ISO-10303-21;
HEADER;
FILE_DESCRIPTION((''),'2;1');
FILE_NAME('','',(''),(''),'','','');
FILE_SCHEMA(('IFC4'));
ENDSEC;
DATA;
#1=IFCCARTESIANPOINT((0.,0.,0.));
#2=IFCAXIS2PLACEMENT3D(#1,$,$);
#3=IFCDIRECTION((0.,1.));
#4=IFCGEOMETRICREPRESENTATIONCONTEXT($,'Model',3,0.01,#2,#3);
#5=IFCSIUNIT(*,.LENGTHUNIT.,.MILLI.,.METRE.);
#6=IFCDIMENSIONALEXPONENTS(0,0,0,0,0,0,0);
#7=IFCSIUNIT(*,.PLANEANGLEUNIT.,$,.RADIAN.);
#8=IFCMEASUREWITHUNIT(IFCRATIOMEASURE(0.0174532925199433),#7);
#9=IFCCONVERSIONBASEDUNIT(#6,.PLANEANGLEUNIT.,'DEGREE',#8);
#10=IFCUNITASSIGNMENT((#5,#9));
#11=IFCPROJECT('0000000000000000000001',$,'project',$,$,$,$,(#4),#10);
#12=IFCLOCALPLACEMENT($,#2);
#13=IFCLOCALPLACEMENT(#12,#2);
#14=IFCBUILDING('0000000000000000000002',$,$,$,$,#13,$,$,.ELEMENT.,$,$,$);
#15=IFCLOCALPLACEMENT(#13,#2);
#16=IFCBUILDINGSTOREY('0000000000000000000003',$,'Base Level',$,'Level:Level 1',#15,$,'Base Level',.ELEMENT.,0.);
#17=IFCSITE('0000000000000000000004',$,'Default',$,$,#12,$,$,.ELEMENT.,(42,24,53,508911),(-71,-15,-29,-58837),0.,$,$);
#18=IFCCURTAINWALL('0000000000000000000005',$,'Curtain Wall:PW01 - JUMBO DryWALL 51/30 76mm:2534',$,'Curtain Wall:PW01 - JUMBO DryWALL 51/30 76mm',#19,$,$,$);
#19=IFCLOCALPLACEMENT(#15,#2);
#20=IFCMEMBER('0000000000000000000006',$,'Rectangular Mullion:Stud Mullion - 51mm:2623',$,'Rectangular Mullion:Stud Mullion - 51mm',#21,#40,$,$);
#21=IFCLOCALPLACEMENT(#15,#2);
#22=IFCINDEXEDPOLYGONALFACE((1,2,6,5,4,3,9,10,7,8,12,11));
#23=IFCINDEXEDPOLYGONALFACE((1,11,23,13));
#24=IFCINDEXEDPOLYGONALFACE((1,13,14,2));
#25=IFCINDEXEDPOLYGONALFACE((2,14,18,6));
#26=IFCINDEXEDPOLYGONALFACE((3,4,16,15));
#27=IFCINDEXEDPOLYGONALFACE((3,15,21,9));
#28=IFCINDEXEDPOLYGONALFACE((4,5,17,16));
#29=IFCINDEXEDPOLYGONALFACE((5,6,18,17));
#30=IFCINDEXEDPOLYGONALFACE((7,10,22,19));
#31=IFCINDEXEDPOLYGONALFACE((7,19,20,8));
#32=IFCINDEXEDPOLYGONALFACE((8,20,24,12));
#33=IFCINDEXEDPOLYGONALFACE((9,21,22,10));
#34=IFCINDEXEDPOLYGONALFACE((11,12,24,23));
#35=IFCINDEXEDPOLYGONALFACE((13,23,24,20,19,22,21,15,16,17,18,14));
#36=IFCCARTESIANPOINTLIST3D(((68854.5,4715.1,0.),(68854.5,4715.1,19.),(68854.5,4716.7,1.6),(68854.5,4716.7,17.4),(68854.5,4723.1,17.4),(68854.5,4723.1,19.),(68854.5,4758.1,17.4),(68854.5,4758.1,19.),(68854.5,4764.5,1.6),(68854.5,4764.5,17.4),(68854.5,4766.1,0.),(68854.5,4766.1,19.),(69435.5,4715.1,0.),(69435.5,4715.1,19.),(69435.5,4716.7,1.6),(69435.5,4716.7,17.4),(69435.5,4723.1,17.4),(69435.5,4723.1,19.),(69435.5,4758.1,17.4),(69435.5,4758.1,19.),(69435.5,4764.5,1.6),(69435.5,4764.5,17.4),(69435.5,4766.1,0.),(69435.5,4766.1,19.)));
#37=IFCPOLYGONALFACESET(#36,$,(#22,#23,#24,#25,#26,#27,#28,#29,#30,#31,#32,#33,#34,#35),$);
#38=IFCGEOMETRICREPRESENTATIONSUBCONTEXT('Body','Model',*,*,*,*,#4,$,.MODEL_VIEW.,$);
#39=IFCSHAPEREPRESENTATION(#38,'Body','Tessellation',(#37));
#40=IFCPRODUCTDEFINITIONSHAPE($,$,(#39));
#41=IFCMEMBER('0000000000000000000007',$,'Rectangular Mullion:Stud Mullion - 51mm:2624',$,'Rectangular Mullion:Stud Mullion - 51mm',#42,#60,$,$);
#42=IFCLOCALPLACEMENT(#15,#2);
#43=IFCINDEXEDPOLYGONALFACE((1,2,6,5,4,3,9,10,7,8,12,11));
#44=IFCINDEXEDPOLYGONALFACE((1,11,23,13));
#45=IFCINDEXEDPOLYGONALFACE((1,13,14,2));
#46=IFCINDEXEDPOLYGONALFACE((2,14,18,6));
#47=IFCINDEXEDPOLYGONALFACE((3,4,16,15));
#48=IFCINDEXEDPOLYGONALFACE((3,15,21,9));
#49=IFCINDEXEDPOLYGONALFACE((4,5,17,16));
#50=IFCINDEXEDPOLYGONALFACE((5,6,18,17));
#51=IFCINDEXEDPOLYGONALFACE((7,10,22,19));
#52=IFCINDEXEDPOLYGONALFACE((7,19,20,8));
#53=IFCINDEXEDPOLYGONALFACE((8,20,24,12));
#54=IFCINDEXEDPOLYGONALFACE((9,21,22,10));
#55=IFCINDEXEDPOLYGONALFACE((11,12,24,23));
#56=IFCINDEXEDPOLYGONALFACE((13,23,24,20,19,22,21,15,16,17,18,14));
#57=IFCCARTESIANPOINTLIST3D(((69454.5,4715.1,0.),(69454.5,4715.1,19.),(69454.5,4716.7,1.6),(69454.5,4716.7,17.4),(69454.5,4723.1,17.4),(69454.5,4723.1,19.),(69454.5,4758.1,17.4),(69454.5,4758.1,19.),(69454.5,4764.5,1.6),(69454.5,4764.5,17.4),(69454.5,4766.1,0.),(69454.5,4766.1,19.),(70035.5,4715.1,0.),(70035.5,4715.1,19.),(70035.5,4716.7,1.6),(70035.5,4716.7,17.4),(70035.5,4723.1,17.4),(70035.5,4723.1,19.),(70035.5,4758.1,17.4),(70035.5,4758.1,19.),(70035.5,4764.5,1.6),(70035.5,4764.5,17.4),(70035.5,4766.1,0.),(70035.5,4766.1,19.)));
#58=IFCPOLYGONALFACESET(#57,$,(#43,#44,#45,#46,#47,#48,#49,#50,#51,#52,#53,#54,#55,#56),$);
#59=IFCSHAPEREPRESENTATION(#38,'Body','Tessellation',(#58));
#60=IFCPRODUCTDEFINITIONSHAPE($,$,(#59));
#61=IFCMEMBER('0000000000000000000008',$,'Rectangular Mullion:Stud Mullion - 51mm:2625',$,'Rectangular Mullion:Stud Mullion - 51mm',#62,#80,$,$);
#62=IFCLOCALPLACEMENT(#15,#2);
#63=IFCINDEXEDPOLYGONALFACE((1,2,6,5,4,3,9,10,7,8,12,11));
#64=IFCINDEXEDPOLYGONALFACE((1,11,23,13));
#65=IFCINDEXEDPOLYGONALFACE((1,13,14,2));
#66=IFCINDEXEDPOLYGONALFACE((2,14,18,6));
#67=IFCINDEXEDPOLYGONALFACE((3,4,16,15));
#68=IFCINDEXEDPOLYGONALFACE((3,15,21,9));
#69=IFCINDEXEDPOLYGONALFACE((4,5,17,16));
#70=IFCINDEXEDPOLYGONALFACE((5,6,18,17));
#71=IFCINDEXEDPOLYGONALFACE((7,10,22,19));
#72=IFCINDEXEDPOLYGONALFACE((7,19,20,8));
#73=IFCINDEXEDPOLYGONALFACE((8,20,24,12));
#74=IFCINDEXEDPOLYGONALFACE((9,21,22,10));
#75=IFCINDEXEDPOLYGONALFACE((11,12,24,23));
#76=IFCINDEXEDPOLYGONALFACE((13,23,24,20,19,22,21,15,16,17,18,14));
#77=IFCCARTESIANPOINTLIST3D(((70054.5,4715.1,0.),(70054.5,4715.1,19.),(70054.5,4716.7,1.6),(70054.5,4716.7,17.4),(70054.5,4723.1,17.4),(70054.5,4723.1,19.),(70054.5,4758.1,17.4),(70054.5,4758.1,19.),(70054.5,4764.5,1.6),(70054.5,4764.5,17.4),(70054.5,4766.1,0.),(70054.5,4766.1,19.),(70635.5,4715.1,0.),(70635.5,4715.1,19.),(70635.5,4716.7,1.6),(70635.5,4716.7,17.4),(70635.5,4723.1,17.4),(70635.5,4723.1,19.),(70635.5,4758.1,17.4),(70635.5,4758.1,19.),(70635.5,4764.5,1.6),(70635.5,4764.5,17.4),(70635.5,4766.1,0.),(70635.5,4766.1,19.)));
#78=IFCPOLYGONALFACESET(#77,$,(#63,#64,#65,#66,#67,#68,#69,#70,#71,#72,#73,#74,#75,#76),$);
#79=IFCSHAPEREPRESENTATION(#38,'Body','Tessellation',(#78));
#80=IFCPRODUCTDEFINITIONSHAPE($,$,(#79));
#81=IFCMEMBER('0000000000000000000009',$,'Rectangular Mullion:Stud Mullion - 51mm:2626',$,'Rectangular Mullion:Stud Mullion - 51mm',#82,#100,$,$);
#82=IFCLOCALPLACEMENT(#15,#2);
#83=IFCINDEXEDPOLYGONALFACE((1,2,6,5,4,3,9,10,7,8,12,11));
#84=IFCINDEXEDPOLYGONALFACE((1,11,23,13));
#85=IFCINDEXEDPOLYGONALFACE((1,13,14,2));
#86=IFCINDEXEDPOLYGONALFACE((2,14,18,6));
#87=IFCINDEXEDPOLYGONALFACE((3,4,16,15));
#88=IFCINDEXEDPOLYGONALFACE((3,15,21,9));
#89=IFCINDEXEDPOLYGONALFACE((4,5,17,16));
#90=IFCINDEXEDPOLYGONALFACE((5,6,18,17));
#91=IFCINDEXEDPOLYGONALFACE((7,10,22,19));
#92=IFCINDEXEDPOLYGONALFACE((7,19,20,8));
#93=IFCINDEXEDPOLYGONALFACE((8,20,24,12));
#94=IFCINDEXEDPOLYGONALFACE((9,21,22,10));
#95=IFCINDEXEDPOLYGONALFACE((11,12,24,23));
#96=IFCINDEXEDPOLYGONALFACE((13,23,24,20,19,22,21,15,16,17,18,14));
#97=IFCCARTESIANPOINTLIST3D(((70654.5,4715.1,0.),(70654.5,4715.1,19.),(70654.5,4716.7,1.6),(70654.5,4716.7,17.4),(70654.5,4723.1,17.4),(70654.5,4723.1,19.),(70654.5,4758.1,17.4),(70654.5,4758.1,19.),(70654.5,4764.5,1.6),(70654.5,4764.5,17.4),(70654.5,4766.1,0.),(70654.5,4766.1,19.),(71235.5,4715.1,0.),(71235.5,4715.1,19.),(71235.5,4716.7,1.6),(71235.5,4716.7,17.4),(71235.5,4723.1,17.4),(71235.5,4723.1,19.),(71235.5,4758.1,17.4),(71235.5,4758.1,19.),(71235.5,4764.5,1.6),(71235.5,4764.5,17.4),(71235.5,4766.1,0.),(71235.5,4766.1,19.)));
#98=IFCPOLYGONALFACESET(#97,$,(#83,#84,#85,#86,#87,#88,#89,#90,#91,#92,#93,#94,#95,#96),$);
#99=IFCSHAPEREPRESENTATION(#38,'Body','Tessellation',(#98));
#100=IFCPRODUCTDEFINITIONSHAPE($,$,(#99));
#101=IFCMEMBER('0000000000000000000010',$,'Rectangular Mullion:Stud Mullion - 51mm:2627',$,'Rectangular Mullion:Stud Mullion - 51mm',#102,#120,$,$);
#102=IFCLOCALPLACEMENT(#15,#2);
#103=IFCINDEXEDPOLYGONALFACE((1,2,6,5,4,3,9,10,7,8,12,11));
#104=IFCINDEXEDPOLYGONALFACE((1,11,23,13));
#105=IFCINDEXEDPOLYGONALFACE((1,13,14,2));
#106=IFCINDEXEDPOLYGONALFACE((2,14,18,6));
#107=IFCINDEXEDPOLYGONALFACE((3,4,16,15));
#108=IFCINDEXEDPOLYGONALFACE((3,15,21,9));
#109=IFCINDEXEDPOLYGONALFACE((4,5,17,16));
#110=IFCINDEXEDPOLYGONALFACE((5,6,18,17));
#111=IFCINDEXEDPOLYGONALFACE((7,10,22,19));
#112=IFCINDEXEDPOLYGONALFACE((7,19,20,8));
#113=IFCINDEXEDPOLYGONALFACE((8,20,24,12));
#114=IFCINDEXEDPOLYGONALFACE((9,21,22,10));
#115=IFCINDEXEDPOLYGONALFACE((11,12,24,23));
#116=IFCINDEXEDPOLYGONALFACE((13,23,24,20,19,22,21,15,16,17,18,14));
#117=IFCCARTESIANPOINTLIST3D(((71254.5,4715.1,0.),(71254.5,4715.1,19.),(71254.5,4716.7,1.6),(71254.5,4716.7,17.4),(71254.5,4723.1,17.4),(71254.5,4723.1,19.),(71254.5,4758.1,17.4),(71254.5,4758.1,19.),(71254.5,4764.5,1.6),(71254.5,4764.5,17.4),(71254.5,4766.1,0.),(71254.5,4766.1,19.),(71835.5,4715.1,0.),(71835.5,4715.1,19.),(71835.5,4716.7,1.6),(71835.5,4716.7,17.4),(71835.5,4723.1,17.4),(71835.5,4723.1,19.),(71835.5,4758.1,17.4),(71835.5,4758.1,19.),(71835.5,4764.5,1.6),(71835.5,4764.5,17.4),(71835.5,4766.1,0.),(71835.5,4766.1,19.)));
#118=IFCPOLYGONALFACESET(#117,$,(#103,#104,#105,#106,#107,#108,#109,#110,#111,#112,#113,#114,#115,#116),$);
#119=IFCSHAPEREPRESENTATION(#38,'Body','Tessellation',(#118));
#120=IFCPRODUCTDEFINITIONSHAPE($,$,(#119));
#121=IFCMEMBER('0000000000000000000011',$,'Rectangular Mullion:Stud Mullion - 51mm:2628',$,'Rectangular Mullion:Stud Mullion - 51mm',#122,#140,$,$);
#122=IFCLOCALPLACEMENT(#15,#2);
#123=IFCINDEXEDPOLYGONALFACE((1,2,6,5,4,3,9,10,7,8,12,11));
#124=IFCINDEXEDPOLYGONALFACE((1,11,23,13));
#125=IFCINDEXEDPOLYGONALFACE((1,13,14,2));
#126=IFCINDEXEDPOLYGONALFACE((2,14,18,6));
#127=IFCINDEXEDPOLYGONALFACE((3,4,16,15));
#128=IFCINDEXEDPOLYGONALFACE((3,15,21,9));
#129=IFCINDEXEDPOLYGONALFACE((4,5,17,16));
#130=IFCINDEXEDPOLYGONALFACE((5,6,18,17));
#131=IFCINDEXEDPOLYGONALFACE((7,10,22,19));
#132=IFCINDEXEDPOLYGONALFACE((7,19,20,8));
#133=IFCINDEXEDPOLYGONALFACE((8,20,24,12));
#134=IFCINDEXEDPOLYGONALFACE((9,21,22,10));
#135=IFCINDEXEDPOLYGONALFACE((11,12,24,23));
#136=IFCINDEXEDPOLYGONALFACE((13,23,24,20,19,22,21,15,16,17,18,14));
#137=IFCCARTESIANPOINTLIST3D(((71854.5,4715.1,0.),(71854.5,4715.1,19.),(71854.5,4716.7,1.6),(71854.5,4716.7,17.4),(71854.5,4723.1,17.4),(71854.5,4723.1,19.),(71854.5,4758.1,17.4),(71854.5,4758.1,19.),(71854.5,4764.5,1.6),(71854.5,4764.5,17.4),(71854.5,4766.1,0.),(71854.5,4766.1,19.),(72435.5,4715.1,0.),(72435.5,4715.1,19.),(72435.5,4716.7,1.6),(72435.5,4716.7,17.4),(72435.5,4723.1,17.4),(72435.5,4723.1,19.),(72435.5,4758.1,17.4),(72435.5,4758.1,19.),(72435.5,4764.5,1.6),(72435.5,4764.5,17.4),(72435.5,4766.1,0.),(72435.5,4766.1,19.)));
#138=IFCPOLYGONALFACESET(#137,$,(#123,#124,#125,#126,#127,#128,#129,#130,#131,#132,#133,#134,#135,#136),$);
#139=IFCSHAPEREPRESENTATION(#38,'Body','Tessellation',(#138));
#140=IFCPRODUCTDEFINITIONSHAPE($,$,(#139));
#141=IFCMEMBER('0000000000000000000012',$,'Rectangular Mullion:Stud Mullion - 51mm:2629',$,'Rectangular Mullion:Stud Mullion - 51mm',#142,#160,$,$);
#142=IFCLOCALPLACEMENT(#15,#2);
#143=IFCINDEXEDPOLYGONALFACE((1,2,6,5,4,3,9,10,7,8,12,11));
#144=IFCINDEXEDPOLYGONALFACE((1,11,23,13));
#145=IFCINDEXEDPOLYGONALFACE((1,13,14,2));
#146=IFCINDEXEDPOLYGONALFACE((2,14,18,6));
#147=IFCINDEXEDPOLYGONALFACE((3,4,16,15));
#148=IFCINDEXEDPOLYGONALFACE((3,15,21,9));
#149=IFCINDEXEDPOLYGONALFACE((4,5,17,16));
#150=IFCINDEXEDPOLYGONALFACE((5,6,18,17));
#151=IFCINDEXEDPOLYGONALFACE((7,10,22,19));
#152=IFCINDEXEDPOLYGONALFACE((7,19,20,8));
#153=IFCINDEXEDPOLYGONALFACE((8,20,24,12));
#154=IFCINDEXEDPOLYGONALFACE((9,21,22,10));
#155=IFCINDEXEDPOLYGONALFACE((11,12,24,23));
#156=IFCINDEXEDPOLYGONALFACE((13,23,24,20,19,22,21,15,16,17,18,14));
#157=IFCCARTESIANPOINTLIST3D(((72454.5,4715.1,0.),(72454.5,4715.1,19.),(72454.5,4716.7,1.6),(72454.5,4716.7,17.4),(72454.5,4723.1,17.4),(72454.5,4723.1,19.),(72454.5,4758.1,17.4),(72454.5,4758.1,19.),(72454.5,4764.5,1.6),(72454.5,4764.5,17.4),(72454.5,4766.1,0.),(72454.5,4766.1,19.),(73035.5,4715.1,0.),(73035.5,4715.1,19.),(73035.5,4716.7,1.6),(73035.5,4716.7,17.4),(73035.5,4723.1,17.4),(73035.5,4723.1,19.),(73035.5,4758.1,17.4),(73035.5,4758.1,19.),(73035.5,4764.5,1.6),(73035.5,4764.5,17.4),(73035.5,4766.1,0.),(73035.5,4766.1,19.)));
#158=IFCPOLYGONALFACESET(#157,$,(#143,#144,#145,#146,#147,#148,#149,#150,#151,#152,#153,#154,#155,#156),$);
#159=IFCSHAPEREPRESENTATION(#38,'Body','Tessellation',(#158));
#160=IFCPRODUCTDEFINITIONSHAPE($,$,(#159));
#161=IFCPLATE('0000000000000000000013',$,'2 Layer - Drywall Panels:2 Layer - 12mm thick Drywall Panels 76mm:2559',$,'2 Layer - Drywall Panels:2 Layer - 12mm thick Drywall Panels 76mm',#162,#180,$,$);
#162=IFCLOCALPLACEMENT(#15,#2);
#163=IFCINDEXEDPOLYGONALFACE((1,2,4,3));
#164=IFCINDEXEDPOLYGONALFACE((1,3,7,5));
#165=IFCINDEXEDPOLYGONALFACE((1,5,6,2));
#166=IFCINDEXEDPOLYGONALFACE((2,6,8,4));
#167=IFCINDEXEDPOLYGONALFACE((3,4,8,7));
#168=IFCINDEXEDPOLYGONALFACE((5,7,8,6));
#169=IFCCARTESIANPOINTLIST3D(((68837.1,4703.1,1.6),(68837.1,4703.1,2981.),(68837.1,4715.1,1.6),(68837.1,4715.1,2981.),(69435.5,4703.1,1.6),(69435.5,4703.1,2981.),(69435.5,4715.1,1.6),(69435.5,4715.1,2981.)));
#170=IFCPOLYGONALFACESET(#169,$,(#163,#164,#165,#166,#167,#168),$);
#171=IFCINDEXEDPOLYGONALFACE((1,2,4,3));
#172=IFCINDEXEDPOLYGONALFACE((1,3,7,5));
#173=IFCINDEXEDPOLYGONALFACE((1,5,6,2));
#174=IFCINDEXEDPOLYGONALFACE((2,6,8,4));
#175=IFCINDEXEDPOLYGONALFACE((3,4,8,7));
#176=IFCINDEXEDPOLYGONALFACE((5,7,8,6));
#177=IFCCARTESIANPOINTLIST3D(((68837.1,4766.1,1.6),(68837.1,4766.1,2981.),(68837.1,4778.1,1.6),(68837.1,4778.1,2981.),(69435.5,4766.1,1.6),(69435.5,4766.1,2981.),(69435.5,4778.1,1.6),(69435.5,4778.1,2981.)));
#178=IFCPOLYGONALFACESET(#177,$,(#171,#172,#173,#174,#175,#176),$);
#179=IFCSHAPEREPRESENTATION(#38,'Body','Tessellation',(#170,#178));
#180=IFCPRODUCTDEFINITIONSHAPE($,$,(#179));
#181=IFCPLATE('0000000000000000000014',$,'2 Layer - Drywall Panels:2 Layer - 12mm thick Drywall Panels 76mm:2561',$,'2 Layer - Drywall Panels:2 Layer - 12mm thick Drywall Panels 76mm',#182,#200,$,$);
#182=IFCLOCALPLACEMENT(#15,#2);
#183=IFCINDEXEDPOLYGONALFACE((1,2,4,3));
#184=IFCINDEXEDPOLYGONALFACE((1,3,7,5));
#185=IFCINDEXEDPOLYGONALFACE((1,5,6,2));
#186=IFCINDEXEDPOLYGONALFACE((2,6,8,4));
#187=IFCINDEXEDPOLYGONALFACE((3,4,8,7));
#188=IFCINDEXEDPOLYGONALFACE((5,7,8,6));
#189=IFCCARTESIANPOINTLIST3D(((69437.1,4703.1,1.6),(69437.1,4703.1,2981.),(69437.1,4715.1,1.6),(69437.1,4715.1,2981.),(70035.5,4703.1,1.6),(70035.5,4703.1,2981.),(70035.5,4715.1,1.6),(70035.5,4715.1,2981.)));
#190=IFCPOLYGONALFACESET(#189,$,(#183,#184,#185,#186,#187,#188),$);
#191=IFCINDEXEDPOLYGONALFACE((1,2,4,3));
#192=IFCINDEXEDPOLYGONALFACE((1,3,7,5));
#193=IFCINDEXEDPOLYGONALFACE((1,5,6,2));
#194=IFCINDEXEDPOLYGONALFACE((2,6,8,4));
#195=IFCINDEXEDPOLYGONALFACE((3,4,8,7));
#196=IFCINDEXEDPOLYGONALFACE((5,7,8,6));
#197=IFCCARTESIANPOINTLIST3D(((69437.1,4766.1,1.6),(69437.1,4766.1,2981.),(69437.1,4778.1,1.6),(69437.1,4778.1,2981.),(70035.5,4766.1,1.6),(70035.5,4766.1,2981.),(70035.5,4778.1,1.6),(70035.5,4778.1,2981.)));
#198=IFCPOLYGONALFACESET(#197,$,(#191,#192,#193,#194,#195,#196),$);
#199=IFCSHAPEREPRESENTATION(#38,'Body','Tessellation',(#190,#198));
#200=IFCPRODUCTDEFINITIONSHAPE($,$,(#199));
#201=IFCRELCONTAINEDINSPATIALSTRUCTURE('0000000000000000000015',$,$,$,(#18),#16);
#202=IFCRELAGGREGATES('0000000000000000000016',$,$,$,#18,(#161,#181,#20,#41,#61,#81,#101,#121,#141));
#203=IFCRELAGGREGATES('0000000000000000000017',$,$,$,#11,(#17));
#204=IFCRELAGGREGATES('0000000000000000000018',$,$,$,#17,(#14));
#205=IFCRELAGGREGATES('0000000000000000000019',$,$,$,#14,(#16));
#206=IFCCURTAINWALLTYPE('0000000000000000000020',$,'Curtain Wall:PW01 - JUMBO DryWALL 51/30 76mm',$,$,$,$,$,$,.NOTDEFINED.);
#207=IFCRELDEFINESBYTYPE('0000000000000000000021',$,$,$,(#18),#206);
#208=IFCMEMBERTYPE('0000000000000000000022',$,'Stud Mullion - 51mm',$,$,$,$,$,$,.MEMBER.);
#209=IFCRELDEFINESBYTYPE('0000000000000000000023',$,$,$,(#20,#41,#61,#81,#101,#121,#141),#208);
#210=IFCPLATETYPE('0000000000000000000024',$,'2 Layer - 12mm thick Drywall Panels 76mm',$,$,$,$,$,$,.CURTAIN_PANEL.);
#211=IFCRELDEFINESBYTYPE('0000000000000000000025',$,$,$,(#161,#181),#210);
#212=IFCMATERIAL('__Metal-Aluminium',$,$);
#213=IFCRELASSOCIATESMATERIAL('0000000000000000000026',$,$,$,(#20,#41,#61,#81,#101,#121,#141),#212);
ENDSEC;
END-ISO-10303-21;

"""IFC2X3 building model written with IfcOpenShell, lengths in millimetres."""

from ifc_helpers import new_model, entity, si_unit, converted_unit, direction, frame, frame_2d, origin, origin_2d_with_axis, place, context, subcontext, project, spatial, polyline, rectangle, outline, extrude, source, transform, mapped, material, type_object, type_shapes, element, aggregate, save


model = new_model("IFC2X3")

# Units and contexts
model_context = context("Model", 3, precision=0.01, world=origin(), true_north=direction((0.0, 1.0)))
body_context = subcontext(model_context, "Body", "Model", "MODEL_VIEW")
ifc_project = project(units=[si_unit("LENGTHUNIT", "METRE", prefix="MILLI"), converted_unit("PLANEANGLEUNIT", "DEGREE", entity("IfcRatioMeasure", 0.0174532925199433), si_unit("PLANEANGLEUNIT", "RADIAN"), dimensions=[0, 0, 0, 0, 0, 0, 0])], contexts=[model_context])

# Site, building, storey
site_placement = place(None, origin())
site = spatial("IfcSite", under=ifc_project, at=site_placement, Name="Default", CompositionType="ELEMENT", RefLatitude=(42, 24, 53, 508911), RefLongitude=(-71, -15, -29, -58837), RefElevation=0.0)
building_placement = place(site_placement, origin())
building = spatial("IfcBuilding", under=site, at=building_placement, CompositionType="ELEMENT")
storey_placement = place(building_placement, origin())
storey = spatial("IfcBuildingStorey", under=building, at=storey_placement, Name="Base Level", ObjectType="Level:Level 1", LongName="Base Level", CompositionType="ELEMENT", Elevation=0.0)

# Curtain wall, members, plates
curtain_wall_type = type_object("IfcCurtainWallType", Name="Curtain Wall:PW01 - JUMBO DryWALL 51/30 76mm", PredefinedType="NOTDEFINED")
curtain_wall_placement = place(building_placement, origin())
curtain_wall = element("IfcCurtainWall", 1, at=curtain_wall_placement, inside=storey, type_object=curtain_wall_type, Name="Curtain Wall:PW01 - JUMBO DryWALL 51/30 76mm:2534", ObjectType="Curtain Wall:PW01 - JUMBO DryWALL 51/30 76mm")
ifc_material = material(Name="__Metal-Aluminium")
member_type_1 = type_object("IfcMemberType", Name="Stud Mullion - 51mm", PredefinedType="MEMBER")
shared_shape_1 = source(origin(), body_context, "Body", "SweptSolid", [
    extrude(outline(polyline([(17.5, -6.6), (25.5, -6.6), (25.5, 12.4), (-25.5, 12.4), (-25.5, -6.6), (-17.5, -6.6), (-17.5, -5.0), (-23.9, -5.0), (-23.9, 10.8), (23.9, 10.8), (23.9, -5.0), (17.5, -5.0), (17.5, -6.6)])), frame((-12.4, 0.0, -581.0), z_axis=(0.0, 0.0, 1.0), x_axis=(0.0, -1.0, 0.0)), (0.0, 0.0, 1.0), 581.0),
])
type_shapes(member_type_1, [shared_shape_1])
member_1_placement = place(building_placement, frame((68854.5, 4740.6, 0.0), z_axis=(-1.0, 0.0, 0.0), x_axis=(0.0, 0.0, -1.0)))
member_1 = element("IfcMember", 2, at=member_1_placement, type_object=member_type_1, material=ifc_material, Name="Rectangular Mullion:Stud Mullion - 51mm:2623", ObjectType="Rectangular Mullion:Stud Mullion - 51mm", context=body_context, shape_type="MappedRepresentation", body=[
    mapped(shared_shape_1, transform((0.0, 0.0, 0.0), scale=1.0)),
])
member_2_placement = place(building_placement, frame((69454.5, 4740.6, 0.0), z_axis=(-1.0, 0.0, 0.0), x_axis=(0.0, 0.0, -1.0)))
member_2 = element("IfcMember", 3, at=member_2_placement, type_object=member_type_1, material=ifc_material, Name="Rectangular Mullion:Stud Mullion - 51mm:2624", ObjectType="Rectangular Mullion:Stud Mullion - 51mm", context=body_context, shape_type="MappedRepresentation", body=[
    mapped(shared_shape_1, transform((0.0, 0.0, 0.0), scale=1.0)),
])
member_3_placement = place(building_placement, frame((70054.5, 4740.6, 0.0), z_axis=(-1.0, 0.0, 0.0), x_axis=(0.0, 0.0, -1.0)))
member_3 = element("IfcMember", 4, at=member_3_placement, type_object=member_type_1, material=ifc_material, Name="Rectangular Mullion:Stud Mullion - 51mm:2625", ObjectType="Rectangular Mullion:Stud Mullion - 51mm", context=body_context, shape_type="MappedRepresentation", body=[
    mapped(shared_shape_1, transform((0.0, 0.0, 0.0), scale=1.0)),
])
member_4_placement = place(building_placement, frame((70654.5, 4740.6, 0.0), z_axis=(-1.0, 0.0, 0.0), x_axis=(0.0, 0.0, -1.0)))
member_4 = element("IfcMember", 5, at=member_4_placement, type_object=member_type_1, material=ifc_material, Name="Rectangular Mullion:Stud Mullion - 51mm:2626", ObjectType="Rectangular Mullion:Stud Mullion - 51mm", context=body_context, shape_type="MappedRepresentation", body=[
    mapped(shared_shape_1, transform((0.0, 0.0, 0.0), scale=1.0)),
])
member_5_placement = place(building_placement, frame((71254.5, 4740.6, 0.0), z_axis=(-1.0, 0.0, 0.0), x_axis=(0.0, 0.0, -1.0)))
member_5 = element("IfcMember", 6, at=member_5_placement, type_object=member_type_1, material=ifc_material, Name="Rectangular Mullion:Stud Mullion - 51mm:2627", ObjectType="Rectangular Mullion:Stud Mullion - 51mm", context=body_context, shape_type="MappedRepresentation", body=[
    mapped(shared_shape_1, transform((0.0, 0.0, 0.0), scale=1.0)),
])
member_6_placement = place(building_placement, frame((71854.5, 4740.6, 0.0), z_axis=(-1.0, 0.0, 0.0), x_axis=(0.0, 0.0, -1.0)))
member_6 = element("IfcMember", 7, at=member_6_placement, type_object=member_type_1, material=ifc_material, Name="Rectangular Mullion:Stud Mullion - 51mm:2628", ObjectType="Rectangular Mullion:Stud Mullion - 51mm", context=body_context, shape_type="MappedRepresentation", body=[
    mapped(shared_shape_1, transform((0.0, 0.0, 0.0), scale=1.0)),
])
member_7_placement = place(building_placement, frame((72454.5, 4740.6, 0.0), z_axis=(-1.0, 0.0, 0.0), x_axis=(0.0, 0.0, -1.0)))
member_7 = element("IfcMember", 8, at=member_7_placement, type_object=member_type_1, material=ifc_material, Name="Rectangular Mullion:Stud Mullion - 51mm:2629", ObjectType="Rectangular Mullion:Stud Mullion - 51mm", context=body_context, shape_type="MappedRepresentation", body=[
    mapped(shared_shape_1, transform((0.0, 0.0, 0.0), scale=1.0)),
])
plate_type = type_object("IfcPlateType", Name="2 Layer - 12mm thick Drywall Panels 76mm", PredefinedType="CURTAIN_PANEL")
shared_shape_2 = source(origin(), body_context, "Body", "SweptSolid", [
    extrude(rectangle(XDim=598.4, YDim=12.0, at=origin_2d_with_axis()), frame((0.0, -31.5, 0.0), z_axis=(0.0, 0.0, 1.0), x_axis=(-1.0, 0.0, 0.0)), (0.0, 0.0, 1.0), 2979.4),
    extrude(rectangle(XDim=12.0, YDim=598.4, at=frame_2d((0.0, 0.0), x_axis=(1.0, 0.0))), frame((0.0, 31.5, 0.0), z_axis=(0.0, 0.0, 1.0), x_axis=(0.0, 1.0, 0.0)), (0.0, 0.0, 1.0), 2979.4),
])
type_shapes(plate_type, [shared_shape_2])
plate_1_placement = place(curtain_wall_placement, frame((69136.3, 4740.6, 1.6)))
plate_1 = element("IfcPlate", 9, at=plate_1_placement, type_object=plate_type, Name="2 Layer - Drywall Panels:2 Layer - 12mm thick Drywall Panels 76mm:2559", ObjectType="2 Layer - Drywall Panels:2 Layer - 12mm thick Drywall Panels 76mm", context=body_context, shape_type="MappedRepresentation", body=[
    mapped(shared_shape_2, transform((0.0, 0.0, 0.0), scale=1.0)),
])
plate_2_placement = place(curtain_wall_placement, frame((69736.3, 4740.6, 1.6)))
plate_2 = element("IfcPlate", 10, at=plate_2_placement, type_object=plate_type, Name="2 Layer - Drywall Panels:2 Layer - 12mm thick Drywall Panels 76mm:2561", ObjectType="2 Layer - Drywall Panels:2 Layer - 12mm thick Drywall Panels 76mm", context=body_context, shape_type="MappedRepresentation", body=[
    mapped(shared_shape_2, transform((0.0, 0.0, 0.0), scale=1.0)),
])
aggregate(curtain_wall, [plate_1, plate_2, member_1, member_2, member_3, member_4, member_5, member_6, member_7])

save(model, "model.ifc")
